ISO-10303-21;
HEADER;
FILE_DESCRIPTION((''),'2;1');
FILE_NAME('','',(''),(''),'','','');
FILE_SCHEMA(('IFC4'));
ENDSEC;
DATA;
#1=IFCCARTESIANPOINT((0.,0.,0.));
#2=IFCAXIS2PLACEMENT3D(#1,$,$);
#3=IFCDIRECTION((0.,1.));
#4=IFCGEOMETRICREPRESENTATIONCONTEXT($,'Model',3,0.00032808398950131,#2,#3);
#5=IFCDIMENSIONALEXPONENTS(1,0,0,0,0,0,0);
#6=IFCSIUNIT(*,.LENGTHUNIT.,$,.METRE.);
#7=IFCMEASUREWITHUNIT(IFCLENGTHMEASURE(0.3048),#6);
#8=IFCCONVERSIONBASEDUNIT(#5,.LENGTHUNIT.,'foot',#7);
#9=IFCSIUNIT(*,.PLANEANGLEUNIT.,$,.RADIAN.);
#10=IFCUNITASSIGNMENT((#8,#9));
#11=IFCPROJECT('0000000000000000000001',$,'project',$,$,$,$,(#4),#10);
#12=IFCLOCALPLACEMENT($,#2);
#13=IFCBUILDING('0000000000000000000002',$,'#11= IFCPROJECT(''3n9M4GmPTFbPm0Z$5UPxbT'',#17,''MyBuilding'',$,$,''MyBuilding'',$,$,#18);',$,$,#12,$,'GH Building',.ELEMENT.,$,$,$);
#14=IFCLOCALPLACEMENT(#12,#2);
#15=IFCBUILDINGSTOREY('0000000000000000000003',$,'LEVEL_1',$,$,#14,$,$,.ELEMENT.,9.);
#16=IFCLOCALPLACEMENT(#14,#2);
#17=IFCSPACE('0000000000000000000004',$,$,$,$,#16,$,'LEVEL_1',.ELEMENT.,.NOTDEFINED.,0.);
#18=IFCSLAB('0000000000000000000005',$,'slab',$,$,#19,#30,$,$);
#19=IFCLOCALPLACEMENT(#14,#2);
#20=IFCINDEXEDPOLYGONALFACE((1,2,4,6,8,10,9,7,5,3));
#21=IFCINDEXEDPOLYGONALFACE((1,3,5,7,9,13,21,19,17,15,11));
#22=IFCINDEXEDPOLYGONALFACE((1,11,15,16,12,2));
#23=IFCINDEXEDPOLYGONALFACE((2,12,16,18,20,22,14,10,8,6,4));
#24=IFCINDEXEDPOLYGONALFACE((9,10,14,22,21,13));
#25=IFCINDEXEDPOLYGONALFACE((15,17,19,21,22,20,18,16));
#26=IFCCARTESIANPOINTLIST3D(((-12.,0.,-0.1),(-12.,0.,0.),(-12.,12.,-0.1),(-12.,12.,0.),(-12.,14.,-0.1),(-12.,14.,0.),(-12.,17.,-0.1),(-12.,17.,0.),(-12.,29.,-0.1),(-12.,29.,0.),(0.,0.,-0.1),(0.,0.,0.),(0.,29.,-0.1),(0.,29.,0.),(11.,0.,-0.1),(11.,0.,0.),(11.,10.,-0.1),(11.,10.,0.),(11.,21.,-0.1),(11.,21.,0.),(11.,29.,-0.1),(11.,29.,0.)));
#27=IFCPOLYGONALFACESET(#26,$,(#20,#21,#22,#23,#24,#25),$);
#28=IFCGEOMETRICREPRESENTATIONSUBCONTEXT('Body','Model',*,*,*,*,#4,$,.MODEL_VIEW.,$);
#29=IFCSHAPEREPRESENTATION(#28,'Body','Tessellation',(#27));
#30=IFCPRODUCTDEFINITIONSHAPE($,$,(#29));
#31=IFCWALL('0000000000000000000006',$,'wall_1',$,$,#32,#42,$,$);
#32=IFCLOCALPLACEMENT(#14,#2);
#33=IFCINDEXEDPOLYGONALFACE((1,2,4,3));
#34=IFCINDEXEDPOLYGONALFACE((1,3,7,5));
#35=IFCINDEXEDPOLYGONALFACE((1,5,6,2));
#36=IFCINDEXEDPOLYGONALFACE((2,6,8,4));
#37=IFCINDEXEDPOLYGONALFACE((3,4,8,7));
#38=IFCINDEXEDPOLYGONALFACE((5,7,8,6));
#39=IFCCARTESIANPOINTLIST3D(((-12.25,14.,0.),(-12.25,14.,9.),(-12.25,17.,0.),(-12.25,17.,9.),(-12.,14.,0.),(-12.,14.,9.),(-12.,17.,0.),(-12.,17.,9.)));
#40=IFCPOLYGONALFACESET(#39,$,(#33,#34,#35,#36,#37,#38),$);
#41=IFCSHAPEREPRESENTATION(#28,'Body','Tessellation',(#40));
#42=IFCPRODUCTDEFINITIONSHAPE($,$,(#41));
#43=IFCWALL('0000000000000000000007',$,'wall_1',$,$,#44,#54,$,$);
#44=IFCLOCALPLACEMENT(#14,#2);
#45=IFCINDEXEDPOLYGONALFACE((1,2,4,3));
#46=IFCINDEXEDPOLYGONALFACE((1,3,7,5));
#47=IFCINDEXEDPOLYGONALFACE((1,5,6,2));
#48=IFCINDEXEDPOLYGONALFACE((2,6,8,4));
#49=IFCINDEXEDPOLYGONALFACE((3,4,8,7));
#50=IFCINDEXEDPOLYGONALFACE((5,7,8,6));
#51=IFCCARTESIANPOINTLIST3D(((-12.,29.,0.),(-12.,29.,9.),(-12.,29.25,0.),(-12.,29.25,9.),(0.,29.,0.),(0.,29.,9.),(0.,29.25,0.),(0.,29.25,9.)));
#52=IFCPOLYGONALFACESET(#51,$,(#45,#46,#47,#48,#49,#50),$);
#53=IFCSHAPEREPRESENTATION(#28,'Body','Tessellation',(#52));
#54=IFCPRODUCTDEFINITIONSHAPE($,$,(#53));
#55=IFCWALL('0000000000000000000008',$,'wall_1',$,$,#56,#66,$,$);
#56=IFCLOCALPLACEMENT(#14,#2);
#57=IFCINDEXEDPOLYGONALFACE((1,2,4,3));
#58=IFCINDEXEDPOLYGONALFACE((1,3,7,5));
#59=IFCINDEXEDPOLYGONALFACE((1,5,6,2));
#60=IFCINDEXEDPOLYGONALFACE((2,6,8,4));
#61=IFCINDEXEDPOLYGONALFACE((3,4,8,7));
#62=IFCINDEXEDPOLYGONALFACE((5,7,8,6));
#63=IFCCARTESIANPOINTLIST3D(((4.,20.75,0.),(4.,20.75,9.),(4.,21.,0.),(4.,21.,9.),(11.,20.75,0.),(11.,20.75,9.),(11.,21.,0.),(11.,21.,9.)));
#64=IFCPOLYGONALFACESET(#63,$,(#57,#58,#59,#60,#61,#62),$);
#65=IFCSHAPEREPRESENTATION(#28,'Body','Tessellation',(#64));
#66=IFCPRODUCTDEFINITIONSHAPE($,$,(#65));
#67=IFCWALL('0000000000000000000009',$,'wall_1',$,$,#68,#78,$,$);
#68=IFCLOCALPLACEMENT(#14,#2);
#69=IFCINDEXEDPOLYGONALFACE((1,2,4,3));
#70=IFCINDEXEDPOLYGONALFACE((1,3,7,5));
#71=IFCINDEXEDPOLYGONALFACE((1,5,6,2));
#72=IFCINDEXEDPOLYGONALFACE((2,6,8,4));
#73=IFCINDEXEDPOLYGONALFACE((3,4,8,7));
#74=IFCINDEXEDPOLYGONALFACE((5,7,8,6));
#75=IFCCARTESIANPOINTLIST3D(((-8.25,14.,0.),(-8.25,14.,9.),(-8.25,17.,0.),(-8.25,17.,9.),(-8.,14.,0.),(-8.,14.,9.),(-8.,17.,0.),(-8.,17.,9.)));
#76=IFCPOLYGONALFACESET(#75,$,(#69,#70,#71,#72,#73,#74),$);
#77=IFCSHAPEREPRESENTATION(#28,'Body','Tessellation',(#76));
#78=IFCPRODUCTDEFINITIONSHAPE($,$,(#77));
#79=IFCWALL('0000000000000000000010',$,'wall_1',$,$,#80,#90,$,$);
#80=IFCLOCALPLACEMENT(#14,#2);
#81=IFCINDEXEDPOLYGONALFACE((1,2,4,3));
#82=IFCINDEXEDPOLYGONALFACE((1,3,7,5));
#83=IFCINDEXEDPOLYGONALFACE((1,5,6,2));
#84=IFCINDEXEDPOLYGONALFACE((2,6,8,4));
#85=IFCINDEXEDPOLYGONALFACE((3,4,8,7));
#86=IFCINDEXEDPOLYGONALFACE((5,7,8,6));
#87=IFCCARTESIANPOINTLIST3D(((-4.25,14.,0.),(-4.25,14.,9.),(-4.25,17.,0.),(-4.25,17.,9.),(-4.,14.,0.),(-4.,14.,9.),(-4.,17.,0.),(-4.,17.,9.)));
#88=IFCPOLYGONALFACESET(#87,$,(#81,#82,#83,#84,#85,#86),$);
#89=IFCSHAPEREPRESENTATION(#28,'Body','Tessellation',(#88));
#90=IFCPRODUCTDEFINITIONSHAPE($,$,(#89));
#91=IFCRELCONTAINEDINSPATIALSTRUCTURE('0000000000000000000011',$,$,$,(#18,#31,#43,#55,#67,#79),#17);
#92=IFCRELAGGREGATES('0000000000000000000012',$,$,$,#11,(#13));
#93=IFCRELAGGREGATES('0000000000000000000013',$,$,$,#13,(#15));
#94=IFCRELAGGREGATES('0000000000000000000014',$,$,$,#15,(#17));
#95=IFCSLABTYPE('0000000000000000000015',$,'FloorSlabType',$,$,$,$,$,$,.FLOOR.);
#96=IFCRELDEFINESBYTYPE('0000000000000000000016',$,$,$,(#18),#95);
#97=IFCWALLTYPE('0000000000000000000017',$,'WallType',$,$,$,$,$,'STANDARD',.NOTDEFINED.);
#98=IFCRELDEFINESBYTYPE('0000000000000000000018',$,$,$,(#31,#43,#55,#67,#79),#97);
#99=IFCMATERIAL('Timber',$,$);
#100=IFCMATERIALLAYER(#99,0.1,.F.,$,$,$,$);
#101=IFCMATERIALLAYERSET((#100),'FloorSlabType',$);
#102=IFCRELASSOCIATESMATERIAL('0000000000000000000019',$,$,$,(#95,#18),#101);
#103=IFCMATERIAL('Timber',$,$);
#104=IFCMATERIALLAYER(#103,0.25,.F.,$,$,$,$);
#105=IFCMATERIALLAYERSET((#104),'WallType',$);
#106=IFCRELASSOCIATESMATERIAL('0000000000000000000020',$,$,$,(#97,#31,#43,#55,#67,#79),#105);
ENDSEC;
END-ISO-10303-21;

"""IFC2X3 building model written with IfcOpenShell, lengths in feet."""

from ifc_helpers import new_model, entity, si_unit, converted_unit, direction, frame, frame_2d, origin, place, context, subcontext, project, spatial, polyline, rectangle, outline, extrude, material, layer, layer_set, layer_usage, type_object, element, save


model = new_model("IFC2X3")

# Units and contexts
model_context = context("Model", 3, precision=0.00032808398950131, world=origin(), true_north=direction((0.0, 1.0)))
body_context = subcontext(model_context, "Body", "Model", "MODEL_VIEW")
ifc_project = project(units=[converted_unit("LENGTHUNIT", "foot", entity("IfcLengthMeasure", 0.3048), si_unit("LENGTHUNIT", "METRE"), dimensions=[1, 0, 0, 0, 0, 0, 0]), si_unit("PLANEANGLEUNIT", "RADIAN")], contexts=[model_context])

# Building, storey, space
building_placement = place(None, origin())
building = spatial("IfcBuilding", under=ifc_project, at=building_placement, Name="#11= IFCPROJECT('3n9M4GmPTFbPm0Z$5UPxbT',#17,'MyBuilding',$,$,'MyBuilding',$,$,#18);", LongName="GH Building", CompositionType="ELEMENT")
storey_placement = place(building_placement, origin())
storey = spatial("IfcBuildingStorey", under=building, at=storey_placement, Name="LEVEL_1", CompositionType="ELEMENT", Elevation=9.0)
space_placement = place(storey_placement, origin())
space = spatial("IfcSpace", under=storey, at=space_placement, LongName="LEVEL_1", CompositionType="ELEMENT", InteriorOrExteriorSpace="NOTDEFINED", ElevationWithFlooring=0.0)

# Slab
ifc_material_1 = material(Name="Timber")
ifc_layer_1 = layer(ifc_material_1, 0.1, ventilated=False)
ifc_layer_set_1 = layer_set([ifc_layer_1], Name="FloorSlabType")
ifc_layer_usage_1 = layer_usage(ifc_layer_set_1, "AXIS3", "NEGATIVE", -0.1)
slab_type = type_object("IfcSlabType", Name="FloorSlabType", PredefinedType="FLOOR", material=ifc_layer_set_1)
slab_placement = place(space_placement, frame((11.0, 29.0, -0.1), z_axis=(0.0, 0.0, 1.0), x_axis=(-1.0, 0.0, 0.0)))
element("IfcSlab", 1, at=slab_placement, inside=space, type_object=slab_type, material=ifc_layer_usage_1, Name="slab", context=body_context, shape_type="SweptSolid", body=[
    extrude(outline(polyline([(0.0, 0.0), (11.0, 0.0), (23.0, 0.0), (23.0, 12.0), (23.0, 15.0), (23.0, 17.0), (23.0, 29.0), (11.0, 29.0), (0.0, 29.0), (0.0, 19.0), (0.0, 8.0), (0.0, 0.0)])), origin(), (0.0, 0.0, 1.0), 0.1),
])

# Shared definitions
ifc_material_2 = material(Name="Timber")
ifc_layer_2 = layer(ifc_material_2, 0.25, ventilated=False)
ifc_layer_set_2 = layer_set([ifc_layer_2], Name="WallType")
wall_type = type_object("IfcWallType", Name="WallType", ElementType="STANDARD", PredefinedType="NOTDEFINED", material=ifc_layer_set_2)

# Wall
ifc_layer_usage_2 = layer_usage(ifc_layer_set_2, "AXIS2", "NEGATIVE", 0.0)
wall_1_placement = place(space_placement, frame((-12.0, 17.0, 0.0), z_axis=(0.0, 0.0, 1.0), x_axis=(0.0, -1.0, 0.0)))
element("IfcWall", 2, at=wall_1_placement, inside=space, type_object=wall_type, material=ifc_layer_usage_2, Name="wall_1", context=body_context, shape_type="SweptSolid", body=[
    extrude(rectangle(XDim=3.0, YDim=0.25, at=frame_2d((1.5, -0.125))), origin(), (0.0, 0.0, 1.0), 9.0),
])

# Wall
ifc_layer_usage_3 = layer_usage(ifc_layer_set_2, "AXIS2", "NEGATIVE", 0.0)
wall_2_placement = place(space_placement, frame((0.0, 29.0, 0.0), z_axis=(0.0, 0.0, 1.0), x_axis=(-1.0, 0.0, 0.0)))
element("IfcWall", 3, at=wall_2_placement, inside=space, type_object=wall_type, material=ifc_layer_usage_3, Name="wall_1", context=body_context, shape_type="SweptSolid", body=[
    extrude(rectangle(XDim=12.0, YDim=0.25, at=frame_2d((6.0, -0.125))), origin(), (0.0, 0.0, 1.0), 9.0),
])

# Wall
ifc_layer_usage_4 = layer_usage(ifc_layer_set_2, "AXIS2", "NEGATIVE", 0.0)
wall_3_placement = place(space_placement, frame((4.0, 21.0, 0.0)))
element("IfcWall", 4, at=wall_3_placement, inside=space, type_object=wall_type, material=ifc_layer_usage_4, Name="wall_1", context=body_context, shape_type="SweptSolid", body=[
    extrude(rectangle(XDim=7.0, YDim=0.25, at=frame_2d((3.5, -0.125))), origin(), (0.0, 0.0, 1.0), 9.0),
])

# Walls
ifc_layer_usage_5 = layer_usage(ifc_layer_set_2, "AXIS2", "NEGATIVE", 0.0)
wall_4_placement = place(space_placement, frame((-8.0, 17.0, 0.0), z_axis=(0.0, 0.0, 1.0), x_axis=(0.0, -1.0, 0.0)))
element("IfcWall", 5, at=wall_4_placement, inside=space, type_object=wall_type, material=ifc_layer_usage_5, Name="wall_1", context=body_context, shape_type="SweptSolid", body=[
    extrude(rectangle(XDim=3.0, YDim=0.25, at=frame_2d((1.5, -0.125))), origin(), (0.0, 0.0, 1.0), 9.0),
])
ifc_layer_usage_6 = layer_usage(ifc_layer_set_2, "AXIS2", "NEGATIVE", 0.0)
wall_5_placement = place(space_placement, frame((-4.0, 17.0, 0.0), z_axis=(0.0, 0.0, 1.0), x_axis=(0.0, -1.0, 0.0)))
element("IfcWall", 6, at=wall_5_placement, inside=space, type_object=wall_type, material=ifc_layer_usage_6, Name="wall_1", context=body_context, shape_type="SweptSolid", body=[
    extrude(rectangle(XDim=3.0, YDim=0.25, at=frame_2d((1.5, -0.125))), origin(), (0.0, 0.0, 1.0), 9.0),
])

save(model, "model.ifc")
